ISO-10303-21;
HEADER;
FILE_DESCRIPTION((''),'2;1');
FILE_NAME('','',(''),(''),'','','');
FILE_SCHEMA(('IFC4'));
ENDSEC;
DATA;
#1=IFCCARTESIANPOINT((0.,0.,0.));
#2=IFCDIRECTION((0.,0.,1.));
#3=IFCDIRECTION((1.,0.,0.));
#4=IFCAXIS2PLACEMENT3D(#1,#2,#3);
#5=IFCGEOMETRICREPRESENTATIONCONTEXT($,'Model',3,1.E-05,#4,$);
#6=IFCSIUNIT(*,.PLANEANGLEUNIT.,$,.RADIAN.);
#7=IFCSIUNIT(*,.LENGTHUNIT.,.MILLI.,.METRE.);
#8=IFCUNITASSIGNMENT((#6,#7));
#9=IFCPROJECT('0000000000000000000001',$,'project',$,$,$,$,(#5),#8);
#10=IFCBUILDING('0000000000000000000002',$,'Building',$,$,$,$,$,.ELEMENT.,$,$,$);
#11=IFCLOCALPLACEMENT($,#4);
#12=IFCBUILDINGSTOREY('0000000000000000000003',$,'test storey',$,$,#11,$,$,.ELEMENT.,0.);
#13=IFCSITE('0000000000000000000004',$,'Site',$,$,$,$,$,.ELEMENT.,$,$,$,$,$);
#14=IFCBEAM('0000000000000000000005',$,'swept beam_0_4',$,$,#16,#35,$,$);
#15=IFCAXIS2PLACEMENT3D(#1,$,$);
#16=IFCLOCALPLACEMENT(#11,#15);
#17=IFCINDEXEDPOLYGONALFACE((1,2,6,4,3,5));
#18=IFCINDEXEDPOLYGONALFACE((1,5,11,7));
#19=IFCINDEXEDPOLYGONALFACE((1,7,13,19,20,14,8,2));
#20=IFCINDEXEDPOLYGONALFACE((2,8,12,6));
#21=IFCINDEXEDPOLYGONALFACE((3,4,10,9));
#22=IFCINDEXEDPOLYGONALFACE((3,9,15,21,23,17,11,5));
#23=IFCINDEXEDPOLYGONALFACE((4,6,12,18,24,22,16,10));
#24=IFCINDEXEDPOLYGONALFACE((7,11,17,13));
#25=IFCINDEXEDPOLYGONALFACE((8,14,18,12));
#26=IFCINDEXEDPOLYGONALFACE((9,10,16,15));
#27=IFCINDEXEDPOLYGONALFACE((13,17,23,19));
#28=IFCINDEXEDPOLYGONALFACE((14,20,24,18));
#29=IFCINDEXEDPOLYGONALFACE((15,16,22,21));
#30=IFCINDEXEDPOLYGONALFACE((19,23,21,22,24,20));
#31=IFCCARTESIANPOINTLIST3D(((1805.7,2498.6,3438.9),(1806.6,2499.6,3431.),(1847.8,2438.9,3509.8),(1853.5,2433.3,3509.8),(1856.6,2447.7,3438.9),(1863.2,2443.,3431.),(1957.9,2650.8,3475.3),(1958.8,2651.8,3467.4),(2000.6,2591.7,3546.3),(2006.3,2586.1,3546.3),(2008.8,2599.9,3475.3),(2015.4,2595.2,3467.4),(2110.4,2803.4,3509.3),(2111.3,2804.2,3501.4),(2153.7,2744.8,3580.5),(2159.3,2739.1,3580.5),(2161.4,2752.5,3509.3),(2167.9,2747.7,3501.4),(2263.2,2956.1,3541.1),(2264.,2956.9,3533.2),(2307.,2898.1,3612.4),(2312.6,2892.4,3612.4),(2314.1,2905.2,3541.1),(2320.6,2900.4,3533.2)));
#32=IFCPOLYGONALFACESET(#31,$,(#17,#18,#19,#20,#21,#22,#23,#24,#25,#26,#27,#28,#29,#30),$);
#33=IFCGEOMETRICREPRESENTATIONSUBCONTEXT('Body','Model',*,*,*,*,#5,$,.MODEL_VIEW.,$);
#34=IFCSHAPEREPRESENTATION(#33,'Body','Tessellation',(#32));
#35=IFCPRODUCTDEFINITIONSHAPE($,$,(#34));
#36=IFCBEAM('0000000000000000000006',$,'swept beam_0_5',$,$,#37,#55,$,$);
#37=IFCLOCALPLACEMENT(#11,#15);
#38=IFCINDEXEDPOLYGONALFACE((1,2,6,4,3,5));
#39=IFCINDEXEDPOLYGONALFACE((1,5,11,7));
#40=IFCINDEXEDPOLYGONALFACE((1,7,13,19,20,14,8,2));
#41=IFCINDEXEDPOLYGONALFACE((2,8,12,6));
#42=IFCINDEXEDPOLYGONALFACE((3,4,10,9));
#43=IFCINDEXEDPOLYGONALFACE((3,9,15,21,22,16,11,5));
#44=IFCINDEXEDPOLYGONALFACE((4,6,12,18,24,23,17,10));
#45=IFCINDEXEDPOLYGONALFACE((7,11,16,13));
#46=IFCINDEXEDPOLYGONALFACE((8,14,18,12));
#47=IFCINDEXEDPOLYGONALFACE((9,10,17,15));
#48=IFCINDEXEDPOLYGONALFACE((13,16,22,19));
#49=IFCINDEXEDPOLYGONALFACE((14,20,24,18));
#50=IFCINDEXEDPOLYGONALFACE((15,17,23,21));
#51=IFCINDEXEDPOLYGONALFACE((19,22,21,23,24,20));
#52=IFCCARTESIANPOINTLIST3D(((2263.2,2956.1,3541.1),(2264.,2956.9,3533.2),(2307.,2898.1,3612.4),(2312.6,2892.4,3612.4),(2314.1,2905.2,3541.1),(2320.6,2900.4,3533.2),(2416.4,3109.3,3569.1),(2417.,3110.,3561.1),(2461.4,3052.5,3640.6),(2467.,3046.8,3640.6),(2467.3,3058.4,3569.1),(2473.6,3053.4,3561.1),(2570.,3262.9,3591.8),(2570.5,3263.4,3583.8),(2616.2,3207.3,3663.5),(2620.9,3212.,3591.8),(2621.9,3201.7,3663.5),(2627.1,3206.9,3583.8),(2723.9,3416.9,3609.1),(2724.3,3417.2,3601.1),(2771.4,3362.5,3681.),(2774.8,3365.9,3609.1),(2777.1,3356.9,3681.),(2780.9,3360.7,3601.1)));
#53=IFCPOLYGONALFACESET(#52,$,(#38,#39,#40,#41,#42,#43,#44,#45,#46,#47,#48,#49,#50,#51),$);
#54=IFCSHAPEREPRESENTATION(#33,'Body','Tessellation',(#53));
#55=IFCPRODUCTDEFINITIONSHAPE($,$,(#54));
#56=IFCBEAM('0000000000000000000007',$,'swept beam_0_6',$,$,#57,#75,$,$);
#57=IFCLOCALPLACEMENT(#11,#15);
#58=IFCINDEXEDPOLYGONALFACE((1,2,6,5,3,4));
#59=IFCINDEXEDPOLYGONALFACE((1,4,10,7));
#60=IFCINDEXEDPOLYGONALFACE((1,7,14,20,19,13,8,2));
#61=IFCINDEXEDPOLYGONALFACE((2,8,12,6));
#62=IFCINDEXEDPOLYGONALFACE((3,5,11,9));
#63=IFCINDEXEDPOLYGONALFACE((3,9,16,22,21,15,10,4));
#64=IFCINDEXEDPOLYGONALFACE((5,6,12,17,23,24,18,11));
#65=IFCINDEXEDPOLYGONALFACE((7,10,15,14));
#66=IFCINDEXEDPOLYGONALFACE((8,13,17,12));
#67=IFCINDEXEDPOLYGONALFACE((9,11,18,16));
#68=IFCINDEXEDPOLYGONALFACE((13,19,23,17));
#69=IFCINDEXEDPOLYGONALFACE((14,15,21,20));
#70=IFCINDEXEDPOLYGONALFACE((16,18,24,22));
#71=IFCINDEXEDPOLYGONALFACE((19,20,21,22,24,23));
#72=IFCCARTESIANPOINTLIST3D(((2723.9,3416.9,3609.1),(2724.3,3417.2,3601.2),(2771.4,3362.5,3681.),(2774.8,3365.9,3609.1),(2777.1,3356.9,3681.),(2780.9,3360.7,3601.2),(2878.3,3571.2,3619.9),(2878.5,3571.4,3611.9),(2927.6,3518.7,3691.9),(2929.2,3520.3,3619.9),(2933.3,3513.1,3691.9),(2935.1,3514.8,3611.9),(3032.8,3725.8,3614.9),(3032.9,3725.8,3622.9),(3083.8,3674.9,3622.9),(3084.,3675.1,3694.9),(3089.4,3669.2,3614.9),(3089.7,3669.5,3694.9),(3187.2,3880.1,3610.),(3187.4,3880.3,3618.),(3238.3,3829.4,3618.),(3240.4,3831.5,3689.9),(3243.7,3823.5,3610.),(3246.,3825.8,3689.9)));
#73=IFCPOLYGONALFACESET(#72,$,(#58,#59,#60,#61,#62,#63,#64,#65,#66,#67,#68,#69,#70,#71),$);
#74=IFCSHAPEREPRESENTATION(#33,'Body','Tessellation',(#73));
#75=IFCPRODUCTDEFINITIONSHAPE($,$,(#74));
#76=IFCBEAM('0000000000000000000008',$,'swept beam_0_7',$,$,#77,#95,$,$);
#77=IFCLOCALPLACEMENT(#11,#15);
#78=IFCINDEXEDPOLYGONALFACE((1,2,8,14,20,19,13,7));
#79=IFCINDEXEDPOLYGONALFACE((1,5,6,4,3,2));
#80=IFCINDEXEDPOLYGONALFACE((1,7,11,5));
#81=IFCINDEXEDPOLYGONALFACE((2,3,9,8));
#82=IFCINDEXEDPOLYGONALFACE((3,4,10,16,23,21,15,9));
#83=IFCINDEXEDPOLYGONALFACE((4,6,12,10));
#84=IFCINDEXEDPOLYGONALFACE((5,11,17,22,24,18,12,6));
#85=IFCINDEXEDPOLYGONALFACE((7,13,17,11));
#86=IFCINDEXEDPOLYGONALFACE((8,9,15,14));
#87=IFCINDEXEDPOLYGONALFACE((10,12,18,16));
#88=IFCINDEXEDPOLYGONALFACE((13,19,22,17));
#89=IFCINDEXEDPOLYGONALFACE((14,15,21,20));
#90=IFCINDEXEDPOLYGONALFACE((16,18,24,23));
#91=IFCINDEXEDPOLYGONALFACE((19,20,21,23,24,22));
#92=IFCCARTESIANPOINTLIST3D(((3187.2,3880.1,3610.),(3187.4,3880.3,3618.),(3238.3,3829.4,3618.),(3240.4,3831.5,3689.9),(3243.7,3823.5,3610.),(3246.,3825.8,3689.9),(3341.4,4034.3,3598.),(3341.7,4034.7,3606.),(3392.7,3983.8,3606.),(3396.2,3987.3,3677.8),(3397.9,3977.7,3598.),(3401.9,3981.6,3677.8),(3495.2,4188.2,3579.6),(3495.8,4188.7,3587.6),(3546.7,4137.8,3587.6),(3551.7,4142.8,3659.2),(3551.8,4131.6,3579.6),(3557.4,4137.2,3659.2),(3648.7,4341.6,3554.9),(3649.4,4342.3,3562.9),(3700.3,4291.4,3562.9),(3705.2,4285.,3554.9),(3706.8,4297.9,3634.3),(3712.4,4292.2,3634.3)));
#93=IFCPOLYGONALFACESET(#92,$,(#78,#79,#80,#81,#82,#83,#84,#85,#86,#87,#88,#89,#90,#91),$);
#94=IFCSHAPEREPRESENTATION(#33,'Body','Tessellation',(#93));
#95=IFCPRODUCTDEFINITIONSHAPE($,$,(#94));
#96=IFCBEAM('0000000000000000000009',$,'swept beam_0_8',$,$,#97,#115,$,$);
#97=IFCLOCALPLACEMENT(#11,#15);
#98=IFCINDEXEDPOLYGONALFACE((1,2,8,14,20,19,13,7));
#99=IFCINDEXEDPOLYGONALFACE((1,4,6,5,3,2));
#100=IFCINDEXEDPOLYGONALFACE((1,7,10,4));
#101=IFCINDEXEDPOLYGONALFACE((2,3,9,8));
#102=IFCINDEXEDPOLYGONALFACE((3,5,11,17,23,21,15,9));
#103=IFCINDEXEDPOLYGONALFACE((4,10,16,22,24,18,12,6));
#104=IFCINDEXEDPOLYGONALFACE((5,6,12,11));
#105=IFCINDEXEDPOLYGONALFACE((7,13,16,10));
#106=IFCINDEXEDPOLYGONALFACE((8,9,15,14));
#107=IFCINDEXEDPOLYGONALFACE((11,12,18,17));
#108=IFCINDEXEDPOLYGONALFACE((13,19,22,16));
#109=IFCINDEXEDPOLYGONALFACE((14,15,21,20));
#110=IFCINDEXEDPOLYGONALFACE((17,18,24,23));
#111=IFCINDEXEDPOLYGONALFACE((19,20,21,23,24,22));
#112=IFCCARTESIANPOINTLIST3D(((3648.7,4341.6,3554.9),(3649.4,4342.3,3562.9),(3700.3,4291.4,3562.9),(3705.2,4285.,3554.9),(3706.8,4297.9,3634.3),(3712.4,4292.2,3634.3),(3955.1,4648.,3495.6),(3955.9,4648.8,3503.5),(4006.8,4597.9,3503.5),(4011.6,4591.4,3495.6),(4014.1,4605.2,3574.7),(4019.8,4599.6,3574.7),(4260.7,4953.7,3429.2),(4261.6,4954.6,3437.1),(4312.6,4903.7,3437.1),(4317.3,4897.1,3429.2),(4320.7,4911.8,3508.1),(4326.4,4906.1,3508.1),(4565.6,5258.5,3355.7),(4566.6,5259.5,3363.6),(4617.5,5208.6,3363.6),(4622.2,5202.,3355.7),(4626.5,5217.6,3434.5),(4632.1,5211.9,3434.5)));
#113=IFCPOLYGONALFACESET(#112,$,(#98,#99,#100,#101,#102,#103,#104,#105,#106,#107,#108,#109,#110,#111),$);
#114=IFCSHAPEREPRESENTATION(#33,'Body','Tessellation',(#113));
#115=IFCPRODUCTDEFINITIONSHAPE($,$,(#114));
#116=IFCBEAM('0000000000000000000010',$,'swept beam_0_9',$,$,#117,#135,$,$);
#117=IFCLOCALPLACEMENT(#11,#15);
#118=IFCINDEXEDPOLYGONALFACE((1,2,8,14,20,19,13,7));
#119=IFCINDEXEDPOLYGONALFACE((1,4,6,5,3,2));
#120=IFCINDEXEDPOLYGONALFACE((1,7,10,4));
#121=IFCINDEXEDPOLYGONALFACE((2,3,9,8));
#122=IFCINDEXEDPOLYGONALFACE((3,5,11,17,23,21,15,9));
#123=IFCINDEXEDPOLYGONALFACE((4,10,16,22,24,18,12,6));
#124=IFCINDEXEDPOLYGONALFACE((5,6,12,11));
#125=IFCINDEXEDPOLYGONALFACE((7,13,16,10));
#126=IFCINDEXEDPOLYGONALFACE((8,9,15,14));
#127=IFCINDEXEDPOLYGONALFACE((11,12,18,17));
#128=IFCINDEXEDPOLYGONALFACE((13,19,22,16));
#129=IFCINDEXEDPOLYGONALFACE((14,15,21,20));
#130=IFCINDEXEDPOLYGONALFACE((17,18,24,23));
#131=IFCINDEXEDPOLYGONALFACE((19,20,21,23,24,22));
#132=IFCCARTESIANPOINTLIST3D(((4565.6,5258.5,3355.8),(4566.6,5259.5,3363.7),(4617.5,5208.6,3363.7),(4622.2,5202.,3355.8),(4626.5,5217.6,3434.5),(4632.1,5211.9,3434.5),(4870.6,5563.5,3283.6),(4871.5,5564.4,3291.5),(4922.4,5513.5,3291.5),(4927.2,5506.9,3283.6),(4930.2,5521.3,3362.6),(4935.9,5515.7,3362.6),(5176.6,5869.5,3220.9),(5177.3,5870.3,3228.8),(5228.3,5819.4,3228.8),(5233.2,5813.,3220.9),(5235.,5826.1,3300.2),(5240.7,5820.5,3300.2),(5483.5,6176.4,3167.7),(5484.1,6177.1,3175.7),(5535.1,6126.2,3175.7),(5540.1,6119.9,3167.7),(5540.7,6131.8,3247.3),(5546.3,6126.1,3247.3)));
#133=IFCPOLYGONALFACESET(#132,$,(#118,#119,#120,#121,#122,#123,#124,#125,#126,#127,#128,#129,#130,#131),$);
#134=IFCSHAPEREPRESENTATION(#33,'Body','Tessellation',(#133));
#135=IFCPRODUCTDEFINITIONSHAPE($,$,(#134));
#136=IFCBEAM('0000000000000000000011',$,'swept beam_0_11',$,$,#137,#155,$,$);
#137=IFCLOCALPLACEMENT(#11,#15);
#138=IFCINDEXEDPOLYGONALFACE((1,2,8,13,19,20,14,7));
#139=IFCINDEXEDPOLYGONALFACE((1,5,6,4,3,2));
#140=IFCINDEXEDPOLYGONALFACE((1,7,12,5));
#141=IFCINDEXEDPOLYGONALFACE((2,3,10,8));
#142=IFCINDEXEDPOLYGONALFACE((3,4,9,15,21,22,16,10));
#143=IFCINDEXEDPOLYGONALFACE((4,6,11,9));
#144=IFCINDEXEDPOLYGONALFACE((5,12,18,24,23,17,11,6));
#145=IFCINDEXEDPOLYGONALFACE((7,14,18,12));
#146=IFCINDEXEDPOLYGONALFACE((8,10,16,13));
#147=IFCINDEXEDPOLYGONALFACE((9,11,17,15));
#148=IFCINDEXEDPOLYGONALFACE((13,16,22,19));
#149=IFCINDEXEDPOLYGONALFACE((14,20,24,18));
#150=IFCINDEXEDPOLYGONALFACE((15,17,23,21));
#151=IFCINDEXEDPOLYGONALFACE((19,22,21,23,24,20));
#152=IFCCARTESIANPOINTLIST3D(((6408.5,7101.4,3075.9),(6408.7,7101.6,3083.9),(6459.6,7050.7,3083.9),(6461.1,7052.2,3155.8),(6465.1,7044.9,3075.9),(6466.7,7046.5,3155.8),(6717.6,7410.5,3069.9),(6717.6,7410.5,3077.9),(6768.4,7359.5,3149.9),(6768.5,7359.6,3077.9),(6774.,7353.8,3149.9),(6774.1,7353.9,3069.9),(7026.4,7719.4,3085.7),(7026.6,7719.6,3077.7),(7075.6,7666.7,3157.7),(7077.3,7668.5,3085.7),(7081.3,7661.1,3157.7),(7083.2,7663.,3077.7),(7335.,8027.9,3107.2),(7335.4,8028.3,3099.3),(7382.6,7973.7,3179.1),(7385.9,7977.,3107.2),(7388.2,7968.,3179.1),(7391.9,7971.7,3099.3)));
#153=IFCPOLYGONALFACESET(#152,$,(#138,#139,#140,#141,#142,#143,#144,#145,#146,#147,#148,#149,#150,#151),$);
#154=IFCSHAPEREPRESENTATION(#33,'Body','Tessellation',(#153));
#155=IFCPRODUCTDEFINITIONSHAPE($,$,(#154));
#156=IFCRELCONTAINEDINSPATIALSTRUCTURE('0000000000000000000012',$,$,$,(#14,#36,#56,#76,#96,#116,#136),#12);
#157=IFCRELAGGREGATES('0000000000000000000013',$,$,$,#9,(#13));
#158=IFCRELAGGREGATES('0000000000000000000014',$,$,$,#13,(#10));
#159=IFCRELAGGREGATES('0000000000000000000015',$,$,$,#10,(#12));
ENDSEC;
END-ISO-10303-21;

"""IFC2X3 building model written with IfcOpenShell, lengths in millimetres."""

from ifc_helpers import new_model, entity, si_unit, origin_with_axes, place, context, subcontext, project, spatial, element, save


model = new_model("IFC2X3")

# Units and contexts
model_context = context("Model", 3, precision=1e-05, world=origin_with_axes())
body_context = subcontext(model_context, "Body", "Model", "MODEL_VIEW")
ifc_project = project(units=[si_unit("PLANEANGLEUNIT", "RADIAN"), si_unit("LENGTHUNIT", "METRE", prefix="MILLI")], contexts=[model_context])

# Site, building, storey
site = spatial("IfcSite", under=ifc_project, Name="Site", CompositionType="ELEMENT")
building = spatial("IfcBuilding", under=site, Name="Building", CompositionType="ELEMENT")
storey_placement = place(None, origin_with_axes())
storey = spatial("IfcBuildingStorey", under=building, at=storey_placement, Name="test storey", CompositionType="ELEMENT", Elevation=0.0)

# Beams
beam_1_placement = place(storey_placement, origin_with_axes())
element("IfcBeam", 1, at=beam_1_placement, inside=storey, Name="swept beam_0_4", context=body_context, shape_type="SweptSolid", body=[
    entity("IfcRevolvedAreaSolid", entity("IfcArbitraryClosedProfileDef", "AREA", None, entity("IfcPolyline", [entity("IfcCartesianPoint", [80.0, -40.0]), entity("IfcCartesianPoint", [80.0, -32.0]), entity("IfcCartesianPoint", [8.0, -32.0]), entity("IfcCartesianPoint", [8.0, 40.0]), entity("IfcCartesianPoint", [0.0, 40.0]), entity("IfcCartesianPoint", [0.0, -40.0]), entity("IfcCartesianPoint", [80.0, -40.0])])), entity("IfcAxis2Placement3D", entity("IfcCartesianPoint", [1834.9, 2471.3, 3431.0]), entity("IfcDirection", [-0.6966, -0.6966, -0.1717]), entity("IfcDirection", [-0.1214, -0.1214, 0.9851])), entity("IfcAxis1Placement", entity("IfcCartesianPoint", [-20530.9, 0.0, 0.0]), entity("IfcDirection", [0.0, 1.0, 0.0])), 0.031897),
])
beam_2_placement = place(storey_placement, origin_with_axes())
element("IfcBeam", 2, at=beam_2_placement, inside=storey, Name="swept beam_0_5", context=body_context, shape_type="SweptSolid", body=[
    entity("IfcRevolvedAreaSolid", entity("IfcArbitraryClosedProfileDef", "AREA", None, entity("IfcPolyline", [entity("IfcCartesianPoint", [80.0, -40.0]), entity("IfcCartesianPoint", [80.0, -32.0]), entity("IfcCartesianPoint", [8.0, -32.0]), entity("IfcCartesianPoint", [8.0, 40.0]), entity("IfcCartesianPoint", [0.0, 40.0]), entity("IfcCartesianPoint", [0.0, -40.0]), entity("IfcCartesianPoint", [80.0, -40.0])])), entity("IfcAxis2Placement3D", entity("IfcCartesianPoint", [2292.3, 2928.7, 3533.2]), entity("IfcDirection", [-0.7001, -0.7001, -0.1402]), entity("IfcDirection", [-0.0991, -0.0991, 0.9901])), entity("IfcAxis1Placement", entity("IfcCartesianPoint", [-8938.4, 0.0, 0.0]), entity("IfcDirection", [0.0, 1.0, 0.0])), 0.07324),
])
beam_3_placement = place(storey_placement, origin_with_axes())
element("IfcBeam", 3, at=beam_3_placement, inside=storey, Name="swept beam_0_6", context=body_context, shape_type="SweptSolid", body=[
    entity("IfcRevolvedAreaSolid", entity("IfcArbitraryClosedProfileDef", "AREA", None, entity("IfcPolyline", [entity("IfcCartesianPoint", [80.0, -40.0]), entity("IfcCartesianPoint", [80.0, -32.0]), entity("IfcCartesianPoint", [8.0, -32.0]), entity("IfcCartesianPoint", [8.0, 40.0]), entity("IfcCartesianPoint", [0.0, 40.0]), entity("IfcCartesianPoint", [0.0, -40.0]), entity("IfcCartesianPoint", [80.0, -40.0])])), entity("IfcAxis2Placement3D", entity("IfcCartesianPoint", [2752.6, 3389.0, 3601.2]), entity("IfcDirection", [-0.7055, -0.7055, -0.0674]), entity("IfcDirection", [-0.0477, -0.0477, 0.9977])), entity("IfcAxis1Placement", entity("IfcCartesianPoint", [-6070.8, 0.0, 0.0]), entity("IfcDirection", [0.0, 1.0, 0.0])), 0.107888),
])
beam_4_placement = place(storey_placement, origin_with_axes())
element("IfcBeam", 4, at=beam_4_placement, inside=storey, Name="swept beam_0_7", context=body_context, shape_type="SweptSolid", body=[
    entity("IfcRevolvedAreaSolid", entity("IfcArbitraryClosedProfileDef", "AREA", None, entity("IfcPolyline", [entity("IfcCartesianPoint", [80.0, -40.0]), entity("IfcCartesianPoint", [80.0, -32.0]), entity("IfcCartesianPoint", [8.0, -32.0]), entity("IfcCartesianPoint", [8.0, 40.0]), entity("IfcCartesianPoint", [0.0, 40.0]), entity("IfcCartesianPoint", [0.0, -40.0]), entity("IfcCartesianPoint", [80.0, -40.0])])), entity("IfcAxis2Placement3D", entity("IfcCartesianPoint", [3215.4, 3851.8, 3610.0]), entity("IfcDirection", [-0.7065, -0.7065, 0.0404]), entity("IfcDirection", [0.0286, 0.0286, 0.9992])), entity("IfcAxis1Placement", entity("IfcCartesianPoint", [-7491.1, 0.0, 0.0]), entity("IfcDirection", [0.0, 1.0, 0.0])), 0.087461),
])
beam_5_placement = place(storey_placement, origin_with_axes())
element("IfcBeam", 5, at=beam_5_placement, inside=storey, Name="swept beam_0_8", context=body_context, shape_type="SweptSolid", body=[
    entity("IfcRevolvedAreaSolid", entity("IfcArbitraryClosedProfileDef", "AREA", None, entity("IfcPolyline", [entity("IfcCartesianPoint", [80.0, -40.0]), entity("IfcCartesianPoint", [80.0, -32.0]), entity("IfcCartesianPoint", [8.0, -32.0]), entity("IfcCartesianPoint", [8.0, 40.0]), entity("IfcCartesianPoint", [0.0, 40.0]), entity("IfcCartesianPoint", [0.0, -40.0]), entity("IfcCartesianPoint", [80.0, -40.0])])), entity("IfcAxis2Placement3D", entity("IfcCartesianPoint", [3676.9, 4313.3, 3554.9]), entity("IfcDirection", [-0.7013, -0.7013, 0.1276]), entity("IfcDirection", [0.0902, 0.0902, 0.9918])), entity("IfcAxis1Placement", entity("IfcCartesianPoint", [-26820.3, 0.0, 0.0]), entity("IfcDirection", [0.0, 1.0, 0.0])), 0.048922),
])
beam_6_placement = place(storey_placement, origin_with_axes())
element("IfcBeam", 6, at=beam_6_placement, inside=storey, Name="swept beam_0_9", context=body_context, shape_type="SweptSolid", body=[
    entity("IfcRevolvedAreaSolid", entity("IfcArbitraryClosedProfileDef", "AREA", None, entity("IfcPolyline", [entity("IfcCartesianPoint", [-80.0, 40.0]), entity("IfcCartesianPoint", [-80.0, 32.0]), entity("IfcCartesianPoint", [-8.0, 32.0]), entity("IfcCartesianPoint", [-8.0, -40.0]), entity("IfcCartesianPoint", [0.0, -40.0]), entity("IfcCartesianPoint", [0.0, 40.0]), entity("IfcCartesianPoint", [-80.0, 40.0])])), entity("IfcAxis2Placement3D", entity("IfcCartesianPoint", [4593.9, 5230.3, 3355.8]), entity("IfcDirection", [-0.6961, -0.6961, 0.1759]), entity("IfcDirection", [-0.1244, -0.1244, -0.9844])), entity("IfcAxis1Placement", entity("IfcCartesianPoint", [-19902.6, 0.0, 0.0]), entity("IfcDirection", [0.0, 1.0, 0.0])), 0.065916),
])
beam_7_placement = place(storey_placement, origin_with_axes())
element("IfcBeam", 7, at=beam_7_placement, inside=storey, Name="swept beam_0_11", context=body_context, shape_type="SweptSolid", body=[
    entity("IfcRevolvedAreaSolid", entity("IfcArbitraryClosedProfileDef", "AREA", None, entity("IfcPolyline", [entity("IfcCartesianPoint", [-80.0, 40.0]), entity("IfcCartesianPoint", [-80.0, 32.0]), entity("IfcCartesianPoint", [-8.0, 32.0]), entity("IfcCartesianPoint", [-8.0, -40.0]), entity("IfcCartesianPoint", [0.0, -40.0]), entity("IfcCartesianPoint", [0.0, 40.0]), entity("IfcCartesianPoint", [-80.0, 40.0])])), entity("IfcAxis2Placement3D", entity("IfcCartesianPoint", [6436.8, 7073.1, 3075.9]), entity("IfcDirection", [-0.7068, -0.7068, 0.0293]), entity("IfcDirection", [-0.0207, -0.0207, -0.9996])), entity("IfcAxis1Placement", entity("IfcCartesianPoint", [-13906.3, 0.0, 0.0]), entity("IfcDirection", [0.0, 1.0, 0.0])), 0.094307),
])

save(model, "model.ifc")
